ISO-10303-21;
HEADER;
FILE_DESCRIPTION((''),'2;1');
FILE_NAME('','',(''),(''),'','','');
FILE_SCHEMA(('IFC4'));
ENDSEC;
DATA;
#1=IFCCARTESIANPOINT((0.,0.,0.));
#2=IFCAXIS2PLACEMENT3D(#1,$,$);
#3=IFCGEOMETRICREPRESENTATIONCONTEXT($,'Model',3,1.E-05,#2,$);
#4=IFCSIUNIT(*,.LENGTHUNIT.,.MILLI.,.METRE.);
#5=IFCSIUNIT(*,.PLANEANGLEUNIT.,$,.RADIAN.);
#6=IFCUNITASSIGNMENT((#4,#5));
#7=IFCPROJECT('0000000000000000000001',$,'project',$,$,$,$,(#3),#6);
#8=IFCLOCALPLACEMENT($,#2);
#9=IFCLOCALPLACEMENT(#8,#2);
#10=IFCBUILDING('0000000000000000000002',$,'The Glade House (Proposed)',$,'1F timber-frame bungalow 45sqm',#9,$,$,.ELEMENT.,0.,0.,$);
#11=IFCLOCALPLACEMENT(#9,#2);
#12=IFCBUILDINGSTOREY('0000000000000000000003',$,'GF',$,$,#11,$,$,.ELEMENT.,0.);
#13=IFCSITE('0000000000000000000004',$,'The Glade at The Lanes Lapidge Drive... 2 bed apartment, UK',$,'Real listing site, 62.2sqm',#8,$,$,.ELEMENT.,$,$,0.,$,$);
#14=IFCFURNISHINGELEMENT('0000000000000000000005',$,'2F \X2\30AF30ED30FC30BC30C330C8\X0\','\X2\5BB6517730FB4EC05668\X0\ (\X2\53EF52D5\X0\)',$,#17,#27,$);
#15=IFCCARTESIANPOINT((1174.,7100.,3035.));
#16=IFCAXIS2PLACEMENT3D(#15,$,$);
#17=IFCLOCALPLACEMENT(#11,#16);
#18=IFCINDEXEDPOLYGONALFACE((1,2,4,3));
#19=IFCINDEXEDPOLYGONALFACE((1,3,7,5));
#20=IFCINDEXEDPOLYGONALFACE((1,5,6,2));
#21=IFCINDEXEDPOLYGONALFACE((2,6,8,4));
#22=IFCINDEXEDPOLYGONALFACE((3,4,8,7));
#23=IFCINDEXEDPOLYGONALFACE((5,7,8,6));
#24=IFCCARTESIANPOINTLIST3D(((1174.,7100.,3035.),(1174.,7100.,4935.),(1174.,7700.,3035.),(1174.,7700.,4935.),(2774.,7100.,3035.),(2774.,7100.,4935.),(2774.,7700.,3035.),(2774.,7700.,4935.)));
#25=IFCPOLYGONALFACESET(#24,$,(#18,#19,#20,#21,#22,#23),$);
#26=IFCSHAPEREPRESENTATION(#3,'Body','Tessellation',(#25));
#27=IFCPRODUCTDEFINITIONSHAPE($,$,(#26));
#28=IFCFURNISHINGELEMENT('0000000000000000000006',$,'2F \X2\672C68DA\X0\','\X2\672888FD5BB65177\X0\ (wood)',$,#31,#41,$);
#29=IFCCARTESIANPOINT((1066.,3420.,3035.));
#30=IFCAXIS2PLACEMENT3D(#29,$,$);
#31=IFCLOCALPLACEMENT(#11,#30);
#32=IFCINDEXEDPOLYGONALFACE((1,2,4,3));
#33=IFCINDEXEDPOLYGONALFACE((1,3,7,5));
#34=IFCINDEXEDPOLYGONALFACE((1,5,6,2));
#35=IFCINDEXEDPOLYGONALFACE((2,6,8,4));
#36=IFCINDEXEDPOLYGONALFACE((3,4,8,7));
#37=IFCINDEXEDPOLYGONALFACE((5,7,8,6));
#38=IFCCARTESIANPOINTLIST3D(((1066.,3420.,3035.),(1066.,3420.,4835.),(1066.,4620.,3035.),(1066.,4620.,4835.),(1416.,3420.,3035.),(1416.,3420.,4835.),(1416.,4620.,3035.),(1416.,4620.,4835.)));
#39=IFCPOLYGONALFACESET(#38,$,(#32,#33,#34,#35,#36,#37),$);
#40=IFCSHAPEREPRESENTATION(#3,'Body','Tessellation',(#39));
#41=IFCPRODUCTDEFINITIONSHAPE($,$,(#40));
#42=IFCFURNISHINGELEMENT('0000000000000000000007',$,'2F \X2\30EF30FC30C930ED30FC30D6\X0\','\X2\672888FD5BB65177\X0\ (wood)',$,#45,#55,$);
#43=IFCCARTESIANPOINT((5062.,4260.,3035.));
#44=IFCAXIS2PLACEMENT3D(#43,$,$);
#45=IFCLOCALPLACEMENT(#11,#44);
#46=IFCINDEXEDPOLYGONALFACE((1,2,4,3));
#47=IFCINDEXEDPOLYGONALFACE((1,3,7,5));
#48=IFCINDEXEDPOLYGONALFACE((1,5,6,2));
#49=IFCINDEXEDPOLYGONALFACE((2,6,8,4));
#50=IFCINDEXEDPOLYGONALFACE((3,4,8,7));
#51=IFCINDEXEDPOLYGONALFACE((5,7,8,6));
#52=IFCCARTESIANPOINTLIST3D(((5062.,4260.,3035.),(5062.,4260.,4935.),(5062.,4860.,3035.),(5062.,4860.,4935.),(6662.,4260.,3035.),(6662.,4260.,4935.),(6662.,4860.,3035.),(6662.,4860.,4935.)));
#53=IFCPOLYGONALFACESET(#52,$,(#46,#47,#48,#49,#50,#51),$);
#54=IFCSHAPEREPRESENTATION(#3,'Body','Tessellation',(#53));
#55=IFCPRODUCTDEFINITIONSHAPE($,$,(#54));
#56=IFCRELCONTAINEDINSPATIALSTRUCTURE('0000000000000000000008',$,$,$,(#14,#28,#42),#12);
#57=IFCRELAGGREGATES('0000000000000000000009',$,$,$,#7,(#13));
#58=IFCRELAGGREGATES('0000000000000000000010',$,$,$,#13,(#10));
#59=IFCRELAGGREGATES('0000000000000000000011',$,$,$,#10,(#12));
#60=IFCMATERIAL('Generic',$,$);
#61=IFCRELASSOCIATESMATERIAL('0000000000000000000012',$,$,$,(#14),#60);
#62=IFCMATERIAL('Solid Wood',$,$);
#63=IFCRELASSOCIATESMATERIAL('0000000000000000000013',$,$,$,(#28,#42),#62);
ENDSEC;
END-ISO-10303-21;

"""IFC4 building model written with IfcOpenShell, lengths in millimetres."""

from ifc_helpers import new_model, si_unit, frame, frame_2d, origin, place, context, project, spatial, rectangle, extrude, material, element, save


model = new_model("IFC4")

# Units and contexts
model_context = context("Model", 3, precision=1e-05, world=origin())
ifc_project = project(units=[si_unit("LENGTHUNIT", "METRE", prefix="MILLI"), si_unit("PLANEANGLEUNIT", "RADIAN")], contexts=[model_context])

# Site, building, storey
site_placement = place(None, origin())
site = spatial("IfcSite", under=ifc_project, at=site_placement, Name="The Glade at The Lanes Lapidge Drive... 2 bed apartment, UK", ObjectType="Real listing site, 62.2sqm", CompositionType="ELEMENT", RefElevation=0.0)
building_placement = place(site_placement, origin())
building = spatial("IfcBuilding", under=site, at=building_placement, Name="The Glade House (Proposed)", ObjectType="1F timber-frame bungalow 45sqm", CompositionType="ELEMENT", ElevationOfRefHeight=0.0, ElevationOfTerrain=0.0)
storey_placement = place(building_placement, origin())
storey = spatial("IfcBuildingStorey", under=building, at=storey_placement, Name="GF", CompositionType="ELEMENT", Elevation=0.0)

# Shared definitions
ifc_material_1 = material(Name="Solid Wood")

# Shared definitions
ifc_material_2 = material(Name="Generic")

# Furnishing elements
furnishing_1_placement = place(storey_placement, frame((1174.0, 7100.0, 3035.0)))
element("IfcFurnishingElement", 1, at=furnishing_1_placement, inside=storey, material=ifc_material_2, Name="2F クローゼット", Description="家具・什器 (可動)", context=model_context, shape_type="SweptSolid", body=[
    extrude(rectangle(XDim=1600.0, YDim=600.0, at=frame_2d((800.0, 300.0))), frame((1174.0, 7100.0, 3035.0)), (0.0, 0.0, 1.0), 1900.0),
])
furnishing_2_placement = place(storey_placement, frame((1066.0, 3420.0, 3035.0)))
element("IfcFurnishingElement", 2, at=furnishing_2_placement, inside=storey, material=ifc_material_1, Name="2F 本棚", Description="木製家具 (wood)", context=model_context, shape_type="SweptSolid", body=[
    extrude(rectangle(XDim=350.0, YDim=1200.0, at=frame_2d((175.0, 600.0))), frame((1066.0, 3420.0, 3035.0)), (0.0, 0.0, 1.0), 1800.0),
])
furnishing_3_placement = place(storey_placement, frame((5062.0, 4260.0, 3035.0)))
element("IfcFurnishingElement", 3, at=furnishing_3_placement, inside=storey, material=ifc_material_1, Name="2F ワードローブ", Description="木製家具 (wood)", context=model_context, shape_type="SweptSolid", body=[
    extrude(rectangle(XDim=1600.0, YDim=600.0, at=frame_2d((800.0, 300.0))), frame((5062.0, 4260.0, 3035.0)), (0.0, 0.0, 1.0), 1900.0),
])

save(model, "model.ifc")
